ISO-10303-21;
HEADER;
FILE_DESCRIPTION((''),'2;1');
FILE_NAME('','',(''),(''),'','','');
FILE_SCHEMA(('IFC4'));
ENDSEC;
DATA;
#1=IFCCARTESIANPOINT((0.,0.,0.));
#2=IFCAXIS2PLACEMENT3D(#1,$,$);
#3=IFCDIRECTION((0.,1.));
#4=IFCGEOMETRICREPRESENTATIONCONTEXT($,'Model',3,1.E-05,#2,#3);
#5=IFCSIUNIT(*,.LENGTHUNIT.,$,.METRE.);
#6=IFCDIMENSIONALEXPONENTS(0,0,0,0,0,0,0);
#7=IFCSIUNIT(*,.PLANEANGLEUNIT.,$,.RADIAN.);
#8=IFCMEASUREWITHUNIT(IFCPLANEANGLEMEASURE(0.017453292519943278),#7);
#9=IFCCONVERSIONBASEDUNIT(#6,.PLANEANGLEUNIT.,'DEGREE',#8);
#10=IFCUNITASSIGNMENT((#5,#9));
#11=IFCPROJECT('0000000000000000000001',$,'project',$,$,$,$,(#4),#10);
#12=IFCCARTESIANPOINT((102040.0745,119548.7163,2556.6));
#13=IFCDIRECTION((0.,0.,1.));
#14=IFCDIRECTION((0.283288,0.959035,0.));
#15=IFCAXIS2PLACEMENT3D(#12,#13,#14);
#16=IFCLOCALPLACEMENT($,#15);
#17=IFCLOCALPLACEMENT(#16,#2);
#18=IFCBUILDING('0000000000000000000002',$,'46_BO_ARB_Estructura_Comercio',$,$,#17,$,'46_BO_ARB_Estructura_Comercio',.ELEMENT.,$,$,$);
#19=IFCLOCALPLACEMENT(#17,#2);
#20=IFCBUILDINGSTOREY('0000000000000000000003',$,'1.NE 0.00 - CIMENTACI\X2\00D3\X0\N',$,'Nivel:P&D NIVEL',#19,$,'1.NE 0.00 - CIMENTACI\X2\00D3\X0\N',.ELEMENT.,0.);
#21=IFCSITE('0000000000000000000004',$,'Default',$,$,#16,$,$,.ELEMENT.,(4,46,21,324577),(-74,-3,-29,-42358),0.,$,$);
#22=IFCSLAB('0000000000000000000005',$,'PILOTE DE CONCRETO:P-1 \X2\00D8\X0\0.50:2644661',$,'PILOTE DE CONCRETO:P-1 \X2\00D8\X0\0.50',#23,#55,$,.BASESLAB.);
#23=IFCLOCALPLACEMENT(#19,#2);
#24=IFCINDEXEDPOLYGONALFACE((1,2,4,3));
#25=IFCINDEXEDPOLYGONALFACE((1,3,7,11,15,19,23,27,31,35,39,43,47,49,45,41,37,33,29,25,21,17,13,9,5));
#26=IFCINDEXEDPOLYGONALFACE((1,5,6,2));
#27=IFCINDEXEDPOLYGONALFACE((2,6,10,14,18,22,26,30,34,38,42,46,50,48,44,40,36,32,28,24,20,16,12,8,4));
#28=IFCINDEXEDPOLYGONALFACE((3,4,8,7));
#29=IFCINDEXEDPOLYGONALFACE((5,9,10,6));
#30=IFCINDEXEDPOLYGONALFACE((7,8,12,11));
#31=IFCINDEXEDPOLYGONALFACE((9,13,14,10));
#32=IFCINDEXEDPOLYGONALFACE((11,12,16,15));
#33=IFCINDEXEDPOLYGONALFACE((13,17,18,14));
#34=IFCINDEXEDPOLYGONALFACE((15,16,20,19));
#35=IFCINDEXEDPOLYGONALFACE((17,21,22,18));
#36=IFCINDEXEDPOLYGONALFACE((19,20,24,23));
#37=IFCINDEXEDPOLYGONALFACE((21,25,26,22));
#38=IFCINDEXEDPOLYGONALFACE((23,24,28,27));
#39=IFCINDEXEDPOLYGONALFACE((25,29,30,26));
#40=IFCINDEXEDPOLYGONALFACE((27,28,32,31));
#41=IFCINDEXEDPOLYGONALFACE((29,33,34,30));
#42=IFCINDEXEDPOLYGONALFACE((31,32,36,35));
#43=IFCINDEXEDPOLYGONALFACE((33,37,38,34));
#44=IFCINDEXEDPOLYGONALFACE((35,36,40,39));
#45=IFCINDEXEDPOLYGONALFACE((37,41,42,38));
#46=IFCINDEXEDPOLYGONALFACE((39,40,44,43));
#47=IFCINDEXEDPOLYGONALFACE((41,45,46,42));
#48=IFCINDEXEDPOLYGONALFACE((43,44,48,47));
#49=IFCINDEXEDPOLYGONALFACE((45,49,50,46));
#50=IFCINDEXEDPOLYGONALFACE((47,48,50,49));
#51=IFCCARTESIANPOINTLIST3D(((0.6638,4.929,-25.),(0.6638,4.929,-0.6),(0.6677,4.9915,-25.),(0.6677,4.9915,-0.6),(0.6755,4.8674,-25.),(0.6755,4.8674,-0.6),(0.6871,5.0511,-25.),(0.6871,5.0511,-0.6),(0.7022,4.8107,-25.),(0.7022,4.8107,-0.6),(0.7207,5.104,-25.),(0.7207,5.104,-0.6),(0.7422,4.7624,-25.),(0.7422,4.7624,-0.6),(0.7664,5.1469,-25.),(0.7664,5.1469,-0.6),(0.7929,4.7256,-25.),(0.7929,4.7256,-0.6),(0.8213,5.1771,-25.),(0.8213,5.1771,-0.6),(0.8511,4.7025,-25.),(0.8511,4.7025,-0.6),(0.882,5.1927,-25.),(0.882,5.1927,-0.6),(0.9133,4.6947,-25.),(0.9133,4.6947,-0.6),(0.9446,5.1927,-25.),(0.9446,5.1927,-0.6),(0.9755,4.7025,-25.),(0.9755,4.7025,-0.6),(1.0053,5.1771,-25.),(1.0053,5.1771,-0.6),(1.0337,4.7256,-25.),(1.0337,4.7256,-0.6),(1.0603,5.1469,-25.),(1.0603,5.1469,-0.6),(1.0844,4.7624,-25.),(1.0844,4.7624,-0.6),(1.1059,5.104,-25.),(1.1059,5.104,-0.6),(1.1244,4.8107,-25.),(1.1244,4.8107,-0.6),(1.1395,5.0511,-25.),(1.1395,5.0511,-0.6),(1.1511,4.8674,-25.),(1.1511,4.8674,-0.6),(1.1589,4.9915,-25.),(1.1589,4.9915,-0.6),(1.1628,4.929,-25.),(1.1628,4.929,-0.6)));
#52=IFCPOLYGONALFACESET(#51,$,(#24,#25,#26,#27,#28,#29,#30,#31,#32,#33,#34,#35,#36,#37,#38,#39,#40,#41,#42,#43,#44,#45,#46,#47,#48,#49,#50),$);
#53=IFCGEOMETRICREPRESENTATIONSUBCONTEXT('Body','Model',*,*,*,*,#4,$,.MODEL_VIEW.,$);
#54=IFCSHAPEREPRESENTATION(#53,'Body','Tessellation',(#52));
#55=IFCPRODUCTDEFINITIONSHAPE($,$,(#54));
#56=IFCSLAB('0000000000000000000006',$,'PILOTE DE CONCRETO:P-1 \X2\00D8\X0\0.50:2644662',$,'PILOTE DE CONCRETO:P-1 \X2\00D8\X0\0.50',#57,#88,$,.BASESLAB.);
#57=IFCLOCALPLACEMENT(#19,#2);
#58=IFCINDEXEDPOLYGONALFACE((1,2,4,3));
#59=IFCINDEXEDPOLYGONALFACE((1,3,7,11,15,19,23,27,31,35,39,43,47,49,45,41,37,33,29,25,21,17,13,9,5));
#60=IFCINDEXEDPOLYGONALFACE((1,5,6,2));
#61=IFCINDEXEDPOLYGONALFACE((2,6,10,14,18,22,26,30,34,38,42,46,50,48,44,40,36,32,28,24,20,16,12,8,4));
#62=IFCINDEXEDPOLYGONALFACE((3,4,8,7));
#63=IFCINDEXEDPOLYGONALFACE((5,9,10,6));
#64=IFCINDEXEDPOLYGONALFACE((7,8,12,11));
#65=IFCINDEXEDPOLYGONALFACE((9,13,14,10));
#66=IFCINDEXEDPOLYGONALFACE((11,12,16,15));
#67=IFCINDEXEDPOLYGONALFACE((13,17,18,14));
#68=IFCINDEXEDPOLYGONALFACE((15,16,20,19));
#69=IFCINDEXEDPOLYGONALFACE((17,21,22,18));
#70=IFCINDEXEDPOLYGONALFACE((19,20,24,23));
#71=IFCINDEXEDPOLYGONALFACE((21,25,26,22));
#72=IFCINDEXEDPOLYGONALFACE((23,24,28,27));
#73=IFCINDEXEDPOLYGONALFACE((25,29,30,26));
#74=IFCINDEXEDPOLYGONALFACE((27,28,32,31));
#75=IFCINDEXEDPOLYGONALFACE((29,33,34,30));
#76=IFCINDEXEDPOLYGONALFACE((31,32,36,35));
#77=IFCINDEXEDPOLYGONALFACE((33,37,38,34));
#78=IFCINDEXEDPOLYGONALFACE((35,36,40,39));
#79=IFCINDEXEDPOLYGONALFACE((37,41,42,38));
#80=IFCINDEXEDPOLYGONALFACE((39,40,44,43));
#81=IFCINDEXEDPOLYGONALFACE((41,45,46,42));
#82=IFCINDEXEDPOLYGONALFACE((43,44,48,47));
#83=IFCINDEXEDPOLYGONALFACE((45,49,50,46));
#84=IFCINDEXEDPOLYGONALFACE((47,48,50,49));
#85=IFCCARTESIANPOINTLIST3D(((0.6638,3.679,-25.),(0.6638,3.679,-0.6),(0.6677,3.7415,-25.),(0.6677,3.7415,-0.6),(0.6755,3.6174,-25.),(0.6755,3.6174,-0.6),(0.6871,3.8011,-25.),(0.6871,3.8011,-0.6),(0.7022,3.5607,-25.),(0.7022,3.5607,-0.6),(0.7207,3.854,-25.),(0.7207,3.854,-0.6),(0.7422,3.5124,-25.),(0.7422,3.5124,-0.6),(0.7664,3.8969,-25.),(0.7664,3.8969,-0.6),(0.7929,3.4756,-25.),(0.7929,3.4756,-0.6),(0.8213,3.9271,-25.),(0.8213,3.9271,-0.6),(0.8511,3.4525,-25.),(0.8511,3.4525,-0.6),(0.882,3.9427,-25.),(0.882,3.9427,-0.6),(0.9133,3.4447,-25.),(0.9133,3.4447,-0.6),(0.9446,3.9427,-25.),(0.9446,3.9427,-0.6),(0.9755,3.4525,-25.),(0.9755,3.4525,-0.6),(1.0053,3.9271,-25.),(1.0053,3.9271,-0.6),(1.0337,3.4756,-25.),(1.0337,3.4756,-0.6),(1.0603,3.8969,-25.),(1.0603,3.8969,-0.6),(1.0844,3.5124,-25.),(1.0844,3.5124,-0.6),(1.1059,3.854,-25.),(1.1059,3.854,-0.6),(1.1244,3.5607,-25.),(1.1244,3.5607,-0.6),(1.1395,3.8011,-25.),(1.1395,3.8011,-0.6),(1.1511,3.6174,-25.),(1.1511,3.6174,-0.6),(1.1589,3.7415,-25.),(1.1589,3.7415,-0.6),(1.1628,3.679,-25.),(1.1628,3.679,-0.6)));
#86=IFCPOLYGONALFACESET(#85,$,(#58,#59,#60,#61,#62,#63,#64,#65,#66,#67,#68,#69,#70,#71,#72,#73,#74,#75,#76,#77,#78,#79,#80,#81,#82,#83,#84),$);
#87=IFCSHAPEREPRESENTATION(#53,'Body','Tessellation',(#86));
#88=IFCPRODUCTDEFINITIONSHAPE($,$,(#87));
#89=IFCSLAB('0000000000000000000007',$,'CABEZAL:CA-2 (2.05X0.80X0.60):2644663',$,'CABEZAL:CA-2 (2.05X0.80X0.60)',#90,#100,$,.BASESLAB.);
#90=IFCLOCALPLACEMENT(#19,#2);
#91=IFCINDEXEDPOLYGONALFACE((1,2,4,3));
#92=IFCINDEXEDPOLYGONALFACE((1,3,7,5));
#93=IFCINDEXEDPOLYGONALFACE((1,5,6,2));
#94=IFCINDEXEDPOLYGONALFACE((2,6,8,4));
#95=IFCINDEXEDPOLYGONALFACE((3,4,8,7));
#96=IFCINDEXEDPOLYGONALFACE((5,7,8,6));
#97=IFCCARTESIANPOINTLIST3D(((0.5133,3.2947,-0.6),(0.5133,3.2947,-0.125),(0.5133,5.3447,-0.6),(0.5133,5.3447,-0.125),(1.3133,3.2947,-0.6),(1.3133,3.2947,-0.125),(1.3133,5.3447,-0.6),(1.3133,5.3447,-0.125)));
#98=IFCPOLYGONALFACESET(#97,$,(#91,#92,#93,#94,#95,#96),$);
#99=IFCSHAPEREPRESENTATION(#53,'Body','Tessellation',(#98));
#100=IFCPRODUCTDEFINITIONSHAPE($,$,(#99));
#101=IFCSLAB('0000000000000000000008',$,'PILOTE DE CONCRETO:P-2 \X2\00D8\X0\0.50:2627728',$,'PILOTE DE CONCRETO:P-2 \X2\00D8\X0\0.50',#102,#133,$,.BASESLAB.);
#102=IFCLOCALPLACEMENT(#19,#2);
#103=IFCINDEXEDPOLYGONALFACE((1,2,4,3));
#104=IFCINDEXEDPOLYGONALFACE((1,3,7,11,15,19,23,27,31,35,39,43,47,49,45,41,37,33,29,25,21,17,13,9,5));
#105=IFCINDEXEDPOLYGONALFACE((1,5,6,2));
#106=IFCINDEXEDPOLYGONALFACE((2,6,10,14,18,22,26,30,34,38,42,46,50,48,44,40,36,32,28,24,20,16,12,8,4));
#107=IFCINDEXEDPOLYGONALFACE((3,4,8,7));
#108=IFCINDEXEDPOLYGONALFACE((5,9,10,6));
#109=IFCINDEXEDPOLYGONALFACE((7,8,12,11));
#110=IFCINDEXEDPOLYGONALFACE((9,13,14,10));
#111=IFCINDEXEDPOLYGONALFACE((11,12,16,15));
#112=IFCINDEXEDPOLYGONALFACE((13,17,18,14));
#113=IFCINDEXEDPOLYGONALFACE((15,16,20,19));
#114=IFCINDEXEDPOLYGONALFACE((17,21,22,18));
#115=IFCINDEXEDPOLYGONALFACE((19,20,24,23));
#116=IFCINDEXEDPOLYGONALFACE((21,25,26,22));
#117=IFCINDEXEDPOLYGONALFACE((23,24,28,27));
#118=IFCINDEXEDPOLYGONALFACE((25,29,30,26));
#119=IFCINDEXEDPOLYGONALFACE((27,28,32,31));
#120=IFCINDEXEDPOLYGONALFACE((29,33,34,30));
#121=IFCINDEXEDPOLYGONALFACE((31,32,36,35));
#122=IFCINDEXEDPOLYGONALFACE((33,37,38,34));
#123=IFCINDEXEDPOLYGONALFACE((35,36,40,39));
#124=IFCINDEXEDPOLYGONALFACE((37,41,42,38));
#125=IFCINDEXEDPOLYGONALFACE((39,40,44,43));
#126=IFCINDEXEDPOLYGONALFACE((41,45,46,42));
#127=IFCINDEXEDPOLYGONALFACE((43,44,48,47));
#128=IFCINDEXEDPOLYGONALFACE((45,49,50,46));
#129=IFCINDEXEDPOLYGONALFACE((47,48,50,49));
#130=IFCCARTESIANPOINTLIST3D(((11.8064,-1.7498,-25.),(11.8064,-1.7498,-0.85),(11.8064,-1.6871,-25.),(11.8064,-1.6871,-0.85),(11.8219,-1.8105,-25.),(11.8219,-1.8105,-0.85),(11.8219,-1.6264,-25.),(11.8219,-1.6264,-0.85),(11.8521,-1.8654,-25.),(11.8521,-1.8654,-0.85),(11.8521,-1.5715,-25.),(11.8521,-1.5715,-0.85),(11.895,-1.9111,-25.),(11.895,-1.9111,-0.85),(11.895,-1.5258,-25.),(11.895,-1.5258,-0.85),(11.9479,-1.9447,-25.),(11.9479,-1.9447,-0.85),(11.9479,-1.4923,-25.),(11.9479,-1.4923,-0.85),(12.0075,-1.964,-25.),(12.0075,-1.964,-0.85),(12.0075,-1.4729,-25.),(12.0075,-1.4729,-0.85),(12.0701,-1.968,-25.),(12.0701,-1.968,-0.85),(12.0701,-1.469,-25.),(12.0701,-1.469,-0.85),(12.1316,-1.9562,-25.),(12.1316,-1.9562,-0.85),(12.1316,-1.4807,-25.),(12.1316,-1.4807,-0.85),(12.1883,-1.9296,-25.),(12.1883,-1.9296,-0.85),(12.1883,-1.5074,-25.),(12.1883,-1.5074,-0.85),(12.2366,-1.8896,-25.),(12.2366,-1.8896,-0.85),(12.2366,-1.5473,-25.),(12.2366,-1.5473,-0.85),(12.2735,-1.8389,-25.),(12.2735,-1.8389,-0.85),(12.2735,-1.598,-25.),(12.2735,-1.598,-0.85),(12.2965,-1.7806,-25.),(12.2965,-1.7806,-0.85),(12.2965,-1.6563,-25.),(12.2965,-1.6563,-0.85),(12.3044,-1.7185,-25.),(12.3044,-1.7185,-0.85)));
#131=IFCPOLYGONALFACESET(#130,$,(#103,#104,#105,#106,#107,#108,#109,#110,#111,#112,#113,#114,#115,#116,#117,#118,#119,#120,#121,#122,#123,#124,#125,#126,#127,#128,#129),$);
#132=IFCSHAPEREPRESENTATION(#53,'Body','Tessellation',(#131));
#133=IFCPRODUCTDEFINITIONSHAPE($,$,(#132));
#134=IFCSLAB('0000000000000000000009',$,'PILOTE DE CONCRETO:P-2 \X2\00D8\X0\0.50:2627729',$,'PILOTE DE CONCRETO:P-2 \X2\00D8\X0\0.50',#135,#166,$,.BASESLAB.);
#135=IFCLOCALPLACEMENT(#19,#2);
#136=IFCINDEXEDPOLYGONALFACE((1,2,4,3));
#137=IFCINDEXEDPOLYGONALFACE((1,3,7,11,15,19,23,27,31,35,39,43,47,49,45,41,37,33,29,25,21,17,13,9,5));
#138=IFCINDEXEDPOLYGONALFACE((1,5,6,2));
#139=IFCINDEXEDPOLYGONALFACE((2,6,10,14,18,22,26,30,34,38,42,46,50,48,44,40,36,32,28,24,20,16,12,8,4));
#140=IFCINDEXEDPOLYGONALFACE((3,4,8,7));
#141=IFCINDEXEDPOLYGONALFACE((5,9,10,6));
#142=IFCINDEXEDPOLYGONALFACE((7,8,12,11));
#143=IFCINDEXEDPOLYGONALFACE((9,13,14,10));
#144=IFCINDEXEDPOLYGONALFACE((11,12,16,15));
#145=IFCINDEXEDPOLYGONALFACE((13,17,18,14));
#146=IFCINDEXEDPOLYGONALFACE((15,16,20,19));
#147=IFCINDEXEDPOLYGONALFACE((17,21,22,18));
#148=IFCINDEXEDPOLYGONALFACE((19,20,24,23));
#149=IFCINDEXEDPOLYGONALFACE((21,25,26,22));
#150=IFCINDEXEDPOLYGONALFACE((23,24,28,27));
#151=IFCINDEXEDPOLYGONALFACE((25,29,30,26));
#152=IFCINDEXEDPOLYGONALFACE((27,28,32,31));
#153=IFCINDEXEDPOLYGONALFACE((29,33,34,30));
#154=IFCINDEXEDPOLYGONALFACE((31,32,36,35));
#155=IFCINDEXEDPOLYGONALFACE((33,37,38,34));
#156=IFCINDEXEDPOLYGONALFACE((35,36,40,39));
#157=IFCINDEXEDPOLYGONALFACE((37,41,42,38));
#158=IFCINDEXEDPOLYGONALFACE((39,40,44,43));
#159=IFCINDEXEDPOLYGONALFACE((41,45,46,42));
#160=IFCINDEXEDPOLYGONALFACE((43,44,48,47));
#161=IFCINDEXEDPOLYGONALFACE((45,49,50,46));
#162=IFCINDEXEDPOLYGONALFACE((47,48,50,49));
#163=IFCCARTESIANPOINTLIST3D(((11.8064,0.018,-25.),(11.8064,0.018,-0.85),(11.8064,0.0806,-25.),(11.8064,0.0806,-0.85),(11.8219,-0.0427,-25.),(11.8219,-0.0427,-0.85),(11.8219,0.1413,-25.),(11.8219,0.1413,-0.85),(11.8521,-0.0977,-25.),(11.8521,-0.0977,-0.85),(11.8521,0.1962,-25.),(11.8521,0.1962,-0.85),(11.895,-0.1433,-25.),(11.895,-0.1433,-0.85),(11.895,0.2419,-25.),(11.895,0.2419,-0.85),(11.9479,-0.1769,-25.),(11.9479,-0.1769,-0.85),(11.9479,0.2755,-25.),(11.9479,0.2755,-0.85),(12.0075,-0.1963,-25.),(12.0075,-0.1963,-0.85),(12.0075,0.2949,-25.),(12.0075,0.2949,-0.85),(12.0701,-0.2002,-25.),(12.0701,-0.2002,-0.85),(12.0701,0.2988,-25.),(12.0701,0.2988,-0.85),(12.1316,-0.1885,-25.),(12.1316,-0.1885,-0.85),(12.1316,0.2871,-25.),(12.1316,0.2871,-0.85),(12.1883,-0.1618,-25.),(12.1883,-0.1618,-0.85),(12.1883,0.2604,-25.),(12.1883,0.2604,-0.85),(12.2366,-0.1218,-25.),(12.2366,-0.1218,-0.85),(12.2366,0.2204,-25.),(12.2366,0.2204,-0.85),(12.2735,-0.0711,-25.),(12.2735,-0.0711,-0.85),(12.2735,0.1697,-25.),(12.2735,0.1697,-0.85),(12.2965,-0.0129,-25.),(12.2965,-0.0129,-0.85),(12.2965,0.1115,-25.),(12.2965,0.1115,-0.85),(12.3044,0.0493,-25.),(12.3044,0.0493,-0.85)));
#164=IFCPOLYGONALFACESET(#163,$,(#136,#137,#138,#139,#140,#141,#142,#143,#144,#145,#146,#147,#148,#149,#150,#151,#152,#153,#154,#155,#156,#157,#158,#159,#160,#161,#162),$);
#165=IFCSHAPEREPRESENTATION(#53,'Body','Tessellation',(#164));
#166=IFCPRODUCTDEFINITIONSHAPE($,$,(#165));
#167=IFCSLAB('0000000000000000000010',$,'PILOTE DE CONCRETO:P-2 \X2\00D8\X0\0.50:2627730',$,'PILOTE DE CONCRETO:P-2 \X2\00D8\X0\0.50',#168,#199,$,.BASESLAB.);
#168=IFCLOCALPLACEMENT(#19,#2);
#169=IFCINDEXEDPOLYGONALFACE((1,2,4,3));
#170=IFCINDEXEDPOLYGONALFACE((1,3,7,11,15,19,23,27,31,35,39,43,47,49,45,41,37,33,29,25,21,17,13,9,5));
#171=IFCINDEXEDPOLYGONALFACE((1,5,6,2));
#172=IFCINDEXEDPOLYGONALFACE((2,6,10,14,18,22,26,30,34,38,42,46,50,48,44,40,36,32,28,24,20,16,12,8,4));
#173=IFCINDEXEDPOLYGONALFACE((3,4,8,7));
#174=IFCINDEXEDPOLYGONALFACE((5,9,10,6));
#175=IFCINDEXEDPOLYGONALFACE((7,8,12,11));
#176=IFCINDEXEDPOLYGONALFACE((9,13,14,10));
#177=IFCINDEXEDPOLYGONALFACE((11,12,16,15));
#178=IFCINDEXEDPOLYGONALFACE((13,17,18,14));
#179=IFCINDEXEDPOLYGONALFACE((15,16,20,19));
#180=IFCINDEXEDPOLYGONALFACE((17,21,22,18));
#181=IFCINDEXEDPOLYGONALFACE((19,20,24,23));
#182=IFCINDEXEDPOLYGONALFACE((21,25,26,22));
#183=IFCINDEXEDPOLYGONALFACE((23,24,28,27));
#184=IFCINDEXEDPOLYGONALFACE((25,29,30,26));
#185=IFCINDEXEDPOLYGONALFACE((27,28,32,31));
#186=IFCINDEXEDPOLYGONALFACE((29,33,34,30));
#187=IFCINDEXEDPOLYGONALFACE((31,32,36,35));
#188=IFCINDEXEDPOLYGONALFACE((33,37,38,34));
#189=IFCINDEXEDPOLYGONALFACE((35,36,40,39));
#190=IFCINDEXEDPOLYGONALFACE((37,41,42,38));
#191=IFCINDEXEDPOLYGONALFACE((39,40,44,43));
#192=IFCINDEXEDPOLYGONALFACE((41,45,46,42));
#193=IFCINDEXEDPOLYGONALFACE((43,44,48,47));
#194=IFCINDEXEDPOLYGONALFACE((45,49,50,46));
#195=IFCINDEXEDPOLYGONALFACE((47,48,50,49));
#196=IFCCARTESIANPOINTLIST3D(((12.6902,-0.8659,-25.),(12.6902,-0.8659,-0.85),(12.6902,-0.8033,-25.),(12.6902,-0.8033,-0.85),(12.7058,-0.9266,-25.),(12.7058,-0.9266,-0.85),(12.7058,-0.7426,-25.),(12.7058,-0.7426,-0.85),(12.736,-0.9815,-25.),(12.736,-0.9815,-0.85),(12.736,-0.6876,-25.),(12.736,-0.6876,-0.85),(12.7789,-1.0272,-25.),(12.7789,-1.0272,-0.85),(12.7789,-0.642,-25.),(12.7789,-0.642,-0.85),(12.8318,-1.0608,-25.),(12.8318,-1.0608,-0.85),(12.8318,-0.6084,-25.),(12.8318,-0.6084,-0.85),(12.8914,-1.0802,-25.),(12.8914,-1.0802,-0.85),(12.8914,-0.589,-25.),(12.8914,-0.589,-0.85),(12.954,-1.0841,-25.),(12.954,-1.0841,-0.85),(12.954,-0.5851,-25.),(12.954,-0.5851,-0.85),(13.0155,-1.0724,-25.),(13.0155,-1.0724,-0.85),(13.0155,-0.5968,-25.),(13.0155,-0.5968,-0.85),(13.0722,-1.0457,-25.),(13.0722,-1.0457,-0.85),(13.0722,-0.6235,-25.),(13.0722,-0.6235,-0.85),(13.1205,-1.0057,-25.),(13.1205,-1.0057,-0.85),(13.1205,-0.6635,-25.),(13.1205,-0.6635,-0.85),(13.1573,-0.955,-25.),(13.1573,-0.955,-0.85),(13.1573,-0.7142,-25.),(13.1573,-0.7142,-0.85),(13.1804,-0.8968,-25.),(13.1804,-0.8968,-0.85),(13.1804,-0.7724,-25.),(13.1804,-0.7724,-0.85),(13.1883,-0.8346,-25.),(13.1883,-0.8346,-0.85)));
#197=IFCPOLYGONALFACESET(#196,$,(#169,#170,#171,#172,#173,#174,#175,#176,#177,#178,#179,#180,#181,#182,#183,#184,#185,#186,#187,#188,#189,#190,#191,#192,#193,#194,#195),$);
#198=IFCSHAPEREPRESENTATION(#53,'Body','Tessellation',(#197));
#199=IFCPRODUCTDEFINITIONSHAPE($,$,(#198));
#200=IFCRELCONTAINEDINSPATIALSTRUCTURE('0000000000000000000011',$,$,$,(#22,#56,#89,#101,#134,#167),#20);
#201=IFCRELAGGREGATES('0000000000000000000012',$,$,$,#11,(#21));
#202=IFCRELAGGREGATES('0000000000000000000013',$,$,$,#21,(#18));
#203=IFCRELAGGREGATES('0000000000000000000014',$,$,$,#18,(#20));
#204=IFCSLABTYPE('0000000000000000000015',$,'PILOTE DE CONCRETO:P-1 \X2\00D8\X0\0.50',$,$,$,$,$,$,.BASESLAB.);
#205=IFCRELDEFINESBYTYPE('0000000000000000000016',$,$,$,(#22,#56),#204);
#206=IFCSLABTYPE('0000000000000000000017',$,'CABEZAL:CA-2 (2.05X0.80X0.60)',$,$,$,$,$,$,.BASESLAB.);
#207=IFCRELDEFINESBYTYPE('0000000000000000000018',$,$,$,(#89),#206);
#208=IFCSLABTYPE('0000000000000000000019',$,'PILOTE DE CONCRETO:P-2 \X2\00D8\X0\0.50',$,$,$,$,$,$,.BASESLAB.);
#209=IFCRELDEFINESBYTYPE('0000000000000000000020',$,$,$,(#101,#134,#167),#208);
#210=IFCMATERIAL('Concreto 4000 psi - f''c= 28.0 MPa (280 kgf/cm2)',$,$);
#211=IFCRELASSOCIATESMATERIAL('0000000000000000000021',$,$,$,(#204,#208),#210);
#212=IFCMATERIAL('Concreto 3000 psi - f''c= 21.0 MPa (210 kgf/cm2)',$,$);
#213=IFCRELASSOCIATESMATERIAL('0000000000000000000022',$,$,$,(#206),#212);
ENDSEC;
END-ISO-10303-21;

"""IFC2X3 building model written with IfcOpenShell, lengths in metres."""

from ifc_helpers import new_model, entity, si_unit, converted_unit, direction, frame, frame_2d, origin, origin_2d_with_axis, place, context, subcontext, project, spatial, rectangle, circle, extrude, material, type_object, element, save


model = new_model("IFC2X3")

# Units and contexts
model_context = context("Model", 3, precision=1e-05, world=origin(), true_north=direction((0.0, 1.0)))
body_context = subcontext(model_context, "Body", "Model", "MODEL_VIEW")
ifc_project = project(units=[si_unit("LENGTHUNIT", "METRE"), converted_unit("PLANEANGLEUNIT", "DEGREE", entity("IfcPlaneAngleMeasure", 0.017453292519943278), si_unit("PLANEANGLEUNIT", "RADIAN"), dimensions=[0, 0, 0, 0, 0, 0, 0])], contexts=[model_context])

# Site, building, storey
site_placement = place(None, frame((102040.0745, 119548.7163, 2556.6), z_axis=(0.0, 0.0, 1.0), x_axis=(0.283288, 0.959035, 0.0)))
site = spatial("IfcSite", under=ifc_project, at=site_placement, Name="Default", CompositionType="ELEMENT", RefLatitude=(4, 46, 21, 324577), RefLongitude=(-74, -3, -29, -42358), RefElevation=0.0)
building_placement = place(site_placement, origin())
building = spatial("IfcBuilding", under=site, at=building_placement, Name="46_BO_ARB_Estructura_Comercio", LongName="46_BO_ARB_Estructura_Comercio", CompositionType="ELEMENT")
storey_placement = place(building_placement, origin())
storey = spatial("IfcBuildingStorey", under=building, at=storey_placement, Name="1.NE 0.00 - CIMENTACIÓN", ObjectType="Nivel:P&D NIVEL", LongName="1.NE 0.00 - CIMENTACIÓN", CompositionType="ELEMENT", Elevation=0.0)

# Shared definitions
ifc_material_1 = material(Name="Concreto 3000 psi - f'c= 21.0 MPa (210 kgf/cm2)")

# Slabs
ifc_material_2 = material(Name="Concreto 4000 psi - f'c= 28.0 MPa (280 kgf/cm2)")
slab_type_1 = type_object("IfcSlabType", Name="PILOTE DE CONCRETO:P-1 Ø0.50", PredefinedType="BASESLAB", material=ifc_material_2)
slab_1_placement = place(storey_placement, origin())
element("IfcSlab", 1, at=slab_1_placement, inside=storey, type_object=slab_type_1, Name="PILOTE DE CONCRETO:P-1 Ø0.50:2644661", ObjectType="PILOTE DE CONCRETO:P-1 Ø0.50", PredefinedType="BASESLAB", context=body_context, shape_type="SweptSolid", body=[
    extrude(circle(Radius=0.25, at=frame_2d((0.0, 0.0), x_axis=(1.0, 0.0))), frame((0.9133, 4.9447, -25.0), z_axis=(0.0, 0.0, 1.0), x_axis=(0.0, -1.0, 0.0)), (0.0, 0.0, 1.0), 24.4),
])
slab_2_placement = place(storey_placement, origin())
element("IfcSlab", 2, at=slab_2_placement, inside=storey, type_object=slab_type_1, Name="PILOTE DE CONCRETO:P-1 Ø0.50:2644662", ObjectType="PILOTE DE CONCRETO:P-1 Ø0.50", PredefinedType="BASESLAB", context=body_context, shape_type="SweptSolid", body=[
    extrude(circle(Radius=0.25, at=frame_2d((0.0, 0.0), x_axis=(1.0, 0.0))), frame((0.9133, 3.6947, -25.0), z_axis=(0.0, 0.0, 1.0), x_axis=(0.0, -1.0, 0.0)), (0.0, 0.0, 1.0), 24.4),
])
slab_type_2 = type_object("IfcSlabType", Name="CABEZAL:CA-2 (2.05X0.80X0.60)", PredefinedType="BASESLAB", material=ifc_material_1)
slab_3_placement = place(storey_placement, origin())
element("IfcSlab", 3, at=slab_3_placement, inside=storey, type_object=slab_type_2, Name="CABEZAL:CA-2 (2.05X0.80X0.60):2644663", ObjectType="CABEZAL:CA-2 (2.05X0.80X0.60)", PredefinedType="BASESLAB", context=body_context, shape_type="SweptSolid", body=[
    extrude(rectangle(XDim=0.475, YDim=2.05, at=origin_2d_with_axis()), frame((0.5133, 4.3197, -0.3625), z_axis=(1.0, 0.0, 0.0), x_axis=(0.0, 0.0, 1.0)), (0.0, 0.0, 1.0), 0.8),
])
slab_type_3 = type_object("IfcSlabType", Name="PILOTE DE CONCRETO:P-2 Ø0.50", PredefinedType="BASESLAB", material=ifc_material_2)
slab_4_placement = place(storey_placement, origin())
element("IfcSlab", 4, at=slab_4_placement, inside=storey, type_object=slab_type_3, Name="PILOTE DE CONCRETO:P-2 Ø0.50:2627728", ObjectType="PILOTE DE CONCRETO:P-2 Ø0.50", PredefinedType="BASESLAB", context=body_context, shape_type="SweptSolid", body=[
    extrude(circle(Radius=0.25, at=frame_2d((0.0, 0.0), x_axis=(1.0, 0.0))), frame((12.0544, -1.7185, -25.0)), (0.0, 0.0, 1.0), 24.15),
])
slab_5_placement = place(storey_placement, origin())
element("IfcSlab", 5, at=slab_5_placement, inside=storey, type_object=slab_type_3, Name="PILOTE DE CONCRETO:P-2 Ø0.50:2627729", ObjectType="PILOTE DE CONCRETO:P-2 Ø0.50", PredefinedType="BASESLAB", context=body_context, shape_type="SweptSolid", body=[
    extrude(circle(Radius=0.25, at=frame_2d((0.0, 0.0), x_axis=(1.0, 0.0))), frame((12.0544, 0.0493, -25.0)), (0.0, 0.0, 1.0), 24.15),
])
slab_6_placement = place(storey_placement, origin())
element("IfcSlab", 6, at=slab_6_placement, inside=storey, type_object=slab_type_3, Name="PILOTE DE CONCRETO:P-2 Ø0.50:2627730", ObjectType="PILOTE DE CONCRETO:P-2 Ø0.50", PredefinedType="BASESLAB", context=body_context, shape_type="SweptSolid", body=[
    extrude(circle(Radius=0.25, at=frame_2d((0.0, 0.0), x_axis=(1.0, 0.0))), frame((12.9383, -0.8346, -25.0)), (0.0, 0.0, 1.0), 24.15),
])

save(model, "model.ifc")
